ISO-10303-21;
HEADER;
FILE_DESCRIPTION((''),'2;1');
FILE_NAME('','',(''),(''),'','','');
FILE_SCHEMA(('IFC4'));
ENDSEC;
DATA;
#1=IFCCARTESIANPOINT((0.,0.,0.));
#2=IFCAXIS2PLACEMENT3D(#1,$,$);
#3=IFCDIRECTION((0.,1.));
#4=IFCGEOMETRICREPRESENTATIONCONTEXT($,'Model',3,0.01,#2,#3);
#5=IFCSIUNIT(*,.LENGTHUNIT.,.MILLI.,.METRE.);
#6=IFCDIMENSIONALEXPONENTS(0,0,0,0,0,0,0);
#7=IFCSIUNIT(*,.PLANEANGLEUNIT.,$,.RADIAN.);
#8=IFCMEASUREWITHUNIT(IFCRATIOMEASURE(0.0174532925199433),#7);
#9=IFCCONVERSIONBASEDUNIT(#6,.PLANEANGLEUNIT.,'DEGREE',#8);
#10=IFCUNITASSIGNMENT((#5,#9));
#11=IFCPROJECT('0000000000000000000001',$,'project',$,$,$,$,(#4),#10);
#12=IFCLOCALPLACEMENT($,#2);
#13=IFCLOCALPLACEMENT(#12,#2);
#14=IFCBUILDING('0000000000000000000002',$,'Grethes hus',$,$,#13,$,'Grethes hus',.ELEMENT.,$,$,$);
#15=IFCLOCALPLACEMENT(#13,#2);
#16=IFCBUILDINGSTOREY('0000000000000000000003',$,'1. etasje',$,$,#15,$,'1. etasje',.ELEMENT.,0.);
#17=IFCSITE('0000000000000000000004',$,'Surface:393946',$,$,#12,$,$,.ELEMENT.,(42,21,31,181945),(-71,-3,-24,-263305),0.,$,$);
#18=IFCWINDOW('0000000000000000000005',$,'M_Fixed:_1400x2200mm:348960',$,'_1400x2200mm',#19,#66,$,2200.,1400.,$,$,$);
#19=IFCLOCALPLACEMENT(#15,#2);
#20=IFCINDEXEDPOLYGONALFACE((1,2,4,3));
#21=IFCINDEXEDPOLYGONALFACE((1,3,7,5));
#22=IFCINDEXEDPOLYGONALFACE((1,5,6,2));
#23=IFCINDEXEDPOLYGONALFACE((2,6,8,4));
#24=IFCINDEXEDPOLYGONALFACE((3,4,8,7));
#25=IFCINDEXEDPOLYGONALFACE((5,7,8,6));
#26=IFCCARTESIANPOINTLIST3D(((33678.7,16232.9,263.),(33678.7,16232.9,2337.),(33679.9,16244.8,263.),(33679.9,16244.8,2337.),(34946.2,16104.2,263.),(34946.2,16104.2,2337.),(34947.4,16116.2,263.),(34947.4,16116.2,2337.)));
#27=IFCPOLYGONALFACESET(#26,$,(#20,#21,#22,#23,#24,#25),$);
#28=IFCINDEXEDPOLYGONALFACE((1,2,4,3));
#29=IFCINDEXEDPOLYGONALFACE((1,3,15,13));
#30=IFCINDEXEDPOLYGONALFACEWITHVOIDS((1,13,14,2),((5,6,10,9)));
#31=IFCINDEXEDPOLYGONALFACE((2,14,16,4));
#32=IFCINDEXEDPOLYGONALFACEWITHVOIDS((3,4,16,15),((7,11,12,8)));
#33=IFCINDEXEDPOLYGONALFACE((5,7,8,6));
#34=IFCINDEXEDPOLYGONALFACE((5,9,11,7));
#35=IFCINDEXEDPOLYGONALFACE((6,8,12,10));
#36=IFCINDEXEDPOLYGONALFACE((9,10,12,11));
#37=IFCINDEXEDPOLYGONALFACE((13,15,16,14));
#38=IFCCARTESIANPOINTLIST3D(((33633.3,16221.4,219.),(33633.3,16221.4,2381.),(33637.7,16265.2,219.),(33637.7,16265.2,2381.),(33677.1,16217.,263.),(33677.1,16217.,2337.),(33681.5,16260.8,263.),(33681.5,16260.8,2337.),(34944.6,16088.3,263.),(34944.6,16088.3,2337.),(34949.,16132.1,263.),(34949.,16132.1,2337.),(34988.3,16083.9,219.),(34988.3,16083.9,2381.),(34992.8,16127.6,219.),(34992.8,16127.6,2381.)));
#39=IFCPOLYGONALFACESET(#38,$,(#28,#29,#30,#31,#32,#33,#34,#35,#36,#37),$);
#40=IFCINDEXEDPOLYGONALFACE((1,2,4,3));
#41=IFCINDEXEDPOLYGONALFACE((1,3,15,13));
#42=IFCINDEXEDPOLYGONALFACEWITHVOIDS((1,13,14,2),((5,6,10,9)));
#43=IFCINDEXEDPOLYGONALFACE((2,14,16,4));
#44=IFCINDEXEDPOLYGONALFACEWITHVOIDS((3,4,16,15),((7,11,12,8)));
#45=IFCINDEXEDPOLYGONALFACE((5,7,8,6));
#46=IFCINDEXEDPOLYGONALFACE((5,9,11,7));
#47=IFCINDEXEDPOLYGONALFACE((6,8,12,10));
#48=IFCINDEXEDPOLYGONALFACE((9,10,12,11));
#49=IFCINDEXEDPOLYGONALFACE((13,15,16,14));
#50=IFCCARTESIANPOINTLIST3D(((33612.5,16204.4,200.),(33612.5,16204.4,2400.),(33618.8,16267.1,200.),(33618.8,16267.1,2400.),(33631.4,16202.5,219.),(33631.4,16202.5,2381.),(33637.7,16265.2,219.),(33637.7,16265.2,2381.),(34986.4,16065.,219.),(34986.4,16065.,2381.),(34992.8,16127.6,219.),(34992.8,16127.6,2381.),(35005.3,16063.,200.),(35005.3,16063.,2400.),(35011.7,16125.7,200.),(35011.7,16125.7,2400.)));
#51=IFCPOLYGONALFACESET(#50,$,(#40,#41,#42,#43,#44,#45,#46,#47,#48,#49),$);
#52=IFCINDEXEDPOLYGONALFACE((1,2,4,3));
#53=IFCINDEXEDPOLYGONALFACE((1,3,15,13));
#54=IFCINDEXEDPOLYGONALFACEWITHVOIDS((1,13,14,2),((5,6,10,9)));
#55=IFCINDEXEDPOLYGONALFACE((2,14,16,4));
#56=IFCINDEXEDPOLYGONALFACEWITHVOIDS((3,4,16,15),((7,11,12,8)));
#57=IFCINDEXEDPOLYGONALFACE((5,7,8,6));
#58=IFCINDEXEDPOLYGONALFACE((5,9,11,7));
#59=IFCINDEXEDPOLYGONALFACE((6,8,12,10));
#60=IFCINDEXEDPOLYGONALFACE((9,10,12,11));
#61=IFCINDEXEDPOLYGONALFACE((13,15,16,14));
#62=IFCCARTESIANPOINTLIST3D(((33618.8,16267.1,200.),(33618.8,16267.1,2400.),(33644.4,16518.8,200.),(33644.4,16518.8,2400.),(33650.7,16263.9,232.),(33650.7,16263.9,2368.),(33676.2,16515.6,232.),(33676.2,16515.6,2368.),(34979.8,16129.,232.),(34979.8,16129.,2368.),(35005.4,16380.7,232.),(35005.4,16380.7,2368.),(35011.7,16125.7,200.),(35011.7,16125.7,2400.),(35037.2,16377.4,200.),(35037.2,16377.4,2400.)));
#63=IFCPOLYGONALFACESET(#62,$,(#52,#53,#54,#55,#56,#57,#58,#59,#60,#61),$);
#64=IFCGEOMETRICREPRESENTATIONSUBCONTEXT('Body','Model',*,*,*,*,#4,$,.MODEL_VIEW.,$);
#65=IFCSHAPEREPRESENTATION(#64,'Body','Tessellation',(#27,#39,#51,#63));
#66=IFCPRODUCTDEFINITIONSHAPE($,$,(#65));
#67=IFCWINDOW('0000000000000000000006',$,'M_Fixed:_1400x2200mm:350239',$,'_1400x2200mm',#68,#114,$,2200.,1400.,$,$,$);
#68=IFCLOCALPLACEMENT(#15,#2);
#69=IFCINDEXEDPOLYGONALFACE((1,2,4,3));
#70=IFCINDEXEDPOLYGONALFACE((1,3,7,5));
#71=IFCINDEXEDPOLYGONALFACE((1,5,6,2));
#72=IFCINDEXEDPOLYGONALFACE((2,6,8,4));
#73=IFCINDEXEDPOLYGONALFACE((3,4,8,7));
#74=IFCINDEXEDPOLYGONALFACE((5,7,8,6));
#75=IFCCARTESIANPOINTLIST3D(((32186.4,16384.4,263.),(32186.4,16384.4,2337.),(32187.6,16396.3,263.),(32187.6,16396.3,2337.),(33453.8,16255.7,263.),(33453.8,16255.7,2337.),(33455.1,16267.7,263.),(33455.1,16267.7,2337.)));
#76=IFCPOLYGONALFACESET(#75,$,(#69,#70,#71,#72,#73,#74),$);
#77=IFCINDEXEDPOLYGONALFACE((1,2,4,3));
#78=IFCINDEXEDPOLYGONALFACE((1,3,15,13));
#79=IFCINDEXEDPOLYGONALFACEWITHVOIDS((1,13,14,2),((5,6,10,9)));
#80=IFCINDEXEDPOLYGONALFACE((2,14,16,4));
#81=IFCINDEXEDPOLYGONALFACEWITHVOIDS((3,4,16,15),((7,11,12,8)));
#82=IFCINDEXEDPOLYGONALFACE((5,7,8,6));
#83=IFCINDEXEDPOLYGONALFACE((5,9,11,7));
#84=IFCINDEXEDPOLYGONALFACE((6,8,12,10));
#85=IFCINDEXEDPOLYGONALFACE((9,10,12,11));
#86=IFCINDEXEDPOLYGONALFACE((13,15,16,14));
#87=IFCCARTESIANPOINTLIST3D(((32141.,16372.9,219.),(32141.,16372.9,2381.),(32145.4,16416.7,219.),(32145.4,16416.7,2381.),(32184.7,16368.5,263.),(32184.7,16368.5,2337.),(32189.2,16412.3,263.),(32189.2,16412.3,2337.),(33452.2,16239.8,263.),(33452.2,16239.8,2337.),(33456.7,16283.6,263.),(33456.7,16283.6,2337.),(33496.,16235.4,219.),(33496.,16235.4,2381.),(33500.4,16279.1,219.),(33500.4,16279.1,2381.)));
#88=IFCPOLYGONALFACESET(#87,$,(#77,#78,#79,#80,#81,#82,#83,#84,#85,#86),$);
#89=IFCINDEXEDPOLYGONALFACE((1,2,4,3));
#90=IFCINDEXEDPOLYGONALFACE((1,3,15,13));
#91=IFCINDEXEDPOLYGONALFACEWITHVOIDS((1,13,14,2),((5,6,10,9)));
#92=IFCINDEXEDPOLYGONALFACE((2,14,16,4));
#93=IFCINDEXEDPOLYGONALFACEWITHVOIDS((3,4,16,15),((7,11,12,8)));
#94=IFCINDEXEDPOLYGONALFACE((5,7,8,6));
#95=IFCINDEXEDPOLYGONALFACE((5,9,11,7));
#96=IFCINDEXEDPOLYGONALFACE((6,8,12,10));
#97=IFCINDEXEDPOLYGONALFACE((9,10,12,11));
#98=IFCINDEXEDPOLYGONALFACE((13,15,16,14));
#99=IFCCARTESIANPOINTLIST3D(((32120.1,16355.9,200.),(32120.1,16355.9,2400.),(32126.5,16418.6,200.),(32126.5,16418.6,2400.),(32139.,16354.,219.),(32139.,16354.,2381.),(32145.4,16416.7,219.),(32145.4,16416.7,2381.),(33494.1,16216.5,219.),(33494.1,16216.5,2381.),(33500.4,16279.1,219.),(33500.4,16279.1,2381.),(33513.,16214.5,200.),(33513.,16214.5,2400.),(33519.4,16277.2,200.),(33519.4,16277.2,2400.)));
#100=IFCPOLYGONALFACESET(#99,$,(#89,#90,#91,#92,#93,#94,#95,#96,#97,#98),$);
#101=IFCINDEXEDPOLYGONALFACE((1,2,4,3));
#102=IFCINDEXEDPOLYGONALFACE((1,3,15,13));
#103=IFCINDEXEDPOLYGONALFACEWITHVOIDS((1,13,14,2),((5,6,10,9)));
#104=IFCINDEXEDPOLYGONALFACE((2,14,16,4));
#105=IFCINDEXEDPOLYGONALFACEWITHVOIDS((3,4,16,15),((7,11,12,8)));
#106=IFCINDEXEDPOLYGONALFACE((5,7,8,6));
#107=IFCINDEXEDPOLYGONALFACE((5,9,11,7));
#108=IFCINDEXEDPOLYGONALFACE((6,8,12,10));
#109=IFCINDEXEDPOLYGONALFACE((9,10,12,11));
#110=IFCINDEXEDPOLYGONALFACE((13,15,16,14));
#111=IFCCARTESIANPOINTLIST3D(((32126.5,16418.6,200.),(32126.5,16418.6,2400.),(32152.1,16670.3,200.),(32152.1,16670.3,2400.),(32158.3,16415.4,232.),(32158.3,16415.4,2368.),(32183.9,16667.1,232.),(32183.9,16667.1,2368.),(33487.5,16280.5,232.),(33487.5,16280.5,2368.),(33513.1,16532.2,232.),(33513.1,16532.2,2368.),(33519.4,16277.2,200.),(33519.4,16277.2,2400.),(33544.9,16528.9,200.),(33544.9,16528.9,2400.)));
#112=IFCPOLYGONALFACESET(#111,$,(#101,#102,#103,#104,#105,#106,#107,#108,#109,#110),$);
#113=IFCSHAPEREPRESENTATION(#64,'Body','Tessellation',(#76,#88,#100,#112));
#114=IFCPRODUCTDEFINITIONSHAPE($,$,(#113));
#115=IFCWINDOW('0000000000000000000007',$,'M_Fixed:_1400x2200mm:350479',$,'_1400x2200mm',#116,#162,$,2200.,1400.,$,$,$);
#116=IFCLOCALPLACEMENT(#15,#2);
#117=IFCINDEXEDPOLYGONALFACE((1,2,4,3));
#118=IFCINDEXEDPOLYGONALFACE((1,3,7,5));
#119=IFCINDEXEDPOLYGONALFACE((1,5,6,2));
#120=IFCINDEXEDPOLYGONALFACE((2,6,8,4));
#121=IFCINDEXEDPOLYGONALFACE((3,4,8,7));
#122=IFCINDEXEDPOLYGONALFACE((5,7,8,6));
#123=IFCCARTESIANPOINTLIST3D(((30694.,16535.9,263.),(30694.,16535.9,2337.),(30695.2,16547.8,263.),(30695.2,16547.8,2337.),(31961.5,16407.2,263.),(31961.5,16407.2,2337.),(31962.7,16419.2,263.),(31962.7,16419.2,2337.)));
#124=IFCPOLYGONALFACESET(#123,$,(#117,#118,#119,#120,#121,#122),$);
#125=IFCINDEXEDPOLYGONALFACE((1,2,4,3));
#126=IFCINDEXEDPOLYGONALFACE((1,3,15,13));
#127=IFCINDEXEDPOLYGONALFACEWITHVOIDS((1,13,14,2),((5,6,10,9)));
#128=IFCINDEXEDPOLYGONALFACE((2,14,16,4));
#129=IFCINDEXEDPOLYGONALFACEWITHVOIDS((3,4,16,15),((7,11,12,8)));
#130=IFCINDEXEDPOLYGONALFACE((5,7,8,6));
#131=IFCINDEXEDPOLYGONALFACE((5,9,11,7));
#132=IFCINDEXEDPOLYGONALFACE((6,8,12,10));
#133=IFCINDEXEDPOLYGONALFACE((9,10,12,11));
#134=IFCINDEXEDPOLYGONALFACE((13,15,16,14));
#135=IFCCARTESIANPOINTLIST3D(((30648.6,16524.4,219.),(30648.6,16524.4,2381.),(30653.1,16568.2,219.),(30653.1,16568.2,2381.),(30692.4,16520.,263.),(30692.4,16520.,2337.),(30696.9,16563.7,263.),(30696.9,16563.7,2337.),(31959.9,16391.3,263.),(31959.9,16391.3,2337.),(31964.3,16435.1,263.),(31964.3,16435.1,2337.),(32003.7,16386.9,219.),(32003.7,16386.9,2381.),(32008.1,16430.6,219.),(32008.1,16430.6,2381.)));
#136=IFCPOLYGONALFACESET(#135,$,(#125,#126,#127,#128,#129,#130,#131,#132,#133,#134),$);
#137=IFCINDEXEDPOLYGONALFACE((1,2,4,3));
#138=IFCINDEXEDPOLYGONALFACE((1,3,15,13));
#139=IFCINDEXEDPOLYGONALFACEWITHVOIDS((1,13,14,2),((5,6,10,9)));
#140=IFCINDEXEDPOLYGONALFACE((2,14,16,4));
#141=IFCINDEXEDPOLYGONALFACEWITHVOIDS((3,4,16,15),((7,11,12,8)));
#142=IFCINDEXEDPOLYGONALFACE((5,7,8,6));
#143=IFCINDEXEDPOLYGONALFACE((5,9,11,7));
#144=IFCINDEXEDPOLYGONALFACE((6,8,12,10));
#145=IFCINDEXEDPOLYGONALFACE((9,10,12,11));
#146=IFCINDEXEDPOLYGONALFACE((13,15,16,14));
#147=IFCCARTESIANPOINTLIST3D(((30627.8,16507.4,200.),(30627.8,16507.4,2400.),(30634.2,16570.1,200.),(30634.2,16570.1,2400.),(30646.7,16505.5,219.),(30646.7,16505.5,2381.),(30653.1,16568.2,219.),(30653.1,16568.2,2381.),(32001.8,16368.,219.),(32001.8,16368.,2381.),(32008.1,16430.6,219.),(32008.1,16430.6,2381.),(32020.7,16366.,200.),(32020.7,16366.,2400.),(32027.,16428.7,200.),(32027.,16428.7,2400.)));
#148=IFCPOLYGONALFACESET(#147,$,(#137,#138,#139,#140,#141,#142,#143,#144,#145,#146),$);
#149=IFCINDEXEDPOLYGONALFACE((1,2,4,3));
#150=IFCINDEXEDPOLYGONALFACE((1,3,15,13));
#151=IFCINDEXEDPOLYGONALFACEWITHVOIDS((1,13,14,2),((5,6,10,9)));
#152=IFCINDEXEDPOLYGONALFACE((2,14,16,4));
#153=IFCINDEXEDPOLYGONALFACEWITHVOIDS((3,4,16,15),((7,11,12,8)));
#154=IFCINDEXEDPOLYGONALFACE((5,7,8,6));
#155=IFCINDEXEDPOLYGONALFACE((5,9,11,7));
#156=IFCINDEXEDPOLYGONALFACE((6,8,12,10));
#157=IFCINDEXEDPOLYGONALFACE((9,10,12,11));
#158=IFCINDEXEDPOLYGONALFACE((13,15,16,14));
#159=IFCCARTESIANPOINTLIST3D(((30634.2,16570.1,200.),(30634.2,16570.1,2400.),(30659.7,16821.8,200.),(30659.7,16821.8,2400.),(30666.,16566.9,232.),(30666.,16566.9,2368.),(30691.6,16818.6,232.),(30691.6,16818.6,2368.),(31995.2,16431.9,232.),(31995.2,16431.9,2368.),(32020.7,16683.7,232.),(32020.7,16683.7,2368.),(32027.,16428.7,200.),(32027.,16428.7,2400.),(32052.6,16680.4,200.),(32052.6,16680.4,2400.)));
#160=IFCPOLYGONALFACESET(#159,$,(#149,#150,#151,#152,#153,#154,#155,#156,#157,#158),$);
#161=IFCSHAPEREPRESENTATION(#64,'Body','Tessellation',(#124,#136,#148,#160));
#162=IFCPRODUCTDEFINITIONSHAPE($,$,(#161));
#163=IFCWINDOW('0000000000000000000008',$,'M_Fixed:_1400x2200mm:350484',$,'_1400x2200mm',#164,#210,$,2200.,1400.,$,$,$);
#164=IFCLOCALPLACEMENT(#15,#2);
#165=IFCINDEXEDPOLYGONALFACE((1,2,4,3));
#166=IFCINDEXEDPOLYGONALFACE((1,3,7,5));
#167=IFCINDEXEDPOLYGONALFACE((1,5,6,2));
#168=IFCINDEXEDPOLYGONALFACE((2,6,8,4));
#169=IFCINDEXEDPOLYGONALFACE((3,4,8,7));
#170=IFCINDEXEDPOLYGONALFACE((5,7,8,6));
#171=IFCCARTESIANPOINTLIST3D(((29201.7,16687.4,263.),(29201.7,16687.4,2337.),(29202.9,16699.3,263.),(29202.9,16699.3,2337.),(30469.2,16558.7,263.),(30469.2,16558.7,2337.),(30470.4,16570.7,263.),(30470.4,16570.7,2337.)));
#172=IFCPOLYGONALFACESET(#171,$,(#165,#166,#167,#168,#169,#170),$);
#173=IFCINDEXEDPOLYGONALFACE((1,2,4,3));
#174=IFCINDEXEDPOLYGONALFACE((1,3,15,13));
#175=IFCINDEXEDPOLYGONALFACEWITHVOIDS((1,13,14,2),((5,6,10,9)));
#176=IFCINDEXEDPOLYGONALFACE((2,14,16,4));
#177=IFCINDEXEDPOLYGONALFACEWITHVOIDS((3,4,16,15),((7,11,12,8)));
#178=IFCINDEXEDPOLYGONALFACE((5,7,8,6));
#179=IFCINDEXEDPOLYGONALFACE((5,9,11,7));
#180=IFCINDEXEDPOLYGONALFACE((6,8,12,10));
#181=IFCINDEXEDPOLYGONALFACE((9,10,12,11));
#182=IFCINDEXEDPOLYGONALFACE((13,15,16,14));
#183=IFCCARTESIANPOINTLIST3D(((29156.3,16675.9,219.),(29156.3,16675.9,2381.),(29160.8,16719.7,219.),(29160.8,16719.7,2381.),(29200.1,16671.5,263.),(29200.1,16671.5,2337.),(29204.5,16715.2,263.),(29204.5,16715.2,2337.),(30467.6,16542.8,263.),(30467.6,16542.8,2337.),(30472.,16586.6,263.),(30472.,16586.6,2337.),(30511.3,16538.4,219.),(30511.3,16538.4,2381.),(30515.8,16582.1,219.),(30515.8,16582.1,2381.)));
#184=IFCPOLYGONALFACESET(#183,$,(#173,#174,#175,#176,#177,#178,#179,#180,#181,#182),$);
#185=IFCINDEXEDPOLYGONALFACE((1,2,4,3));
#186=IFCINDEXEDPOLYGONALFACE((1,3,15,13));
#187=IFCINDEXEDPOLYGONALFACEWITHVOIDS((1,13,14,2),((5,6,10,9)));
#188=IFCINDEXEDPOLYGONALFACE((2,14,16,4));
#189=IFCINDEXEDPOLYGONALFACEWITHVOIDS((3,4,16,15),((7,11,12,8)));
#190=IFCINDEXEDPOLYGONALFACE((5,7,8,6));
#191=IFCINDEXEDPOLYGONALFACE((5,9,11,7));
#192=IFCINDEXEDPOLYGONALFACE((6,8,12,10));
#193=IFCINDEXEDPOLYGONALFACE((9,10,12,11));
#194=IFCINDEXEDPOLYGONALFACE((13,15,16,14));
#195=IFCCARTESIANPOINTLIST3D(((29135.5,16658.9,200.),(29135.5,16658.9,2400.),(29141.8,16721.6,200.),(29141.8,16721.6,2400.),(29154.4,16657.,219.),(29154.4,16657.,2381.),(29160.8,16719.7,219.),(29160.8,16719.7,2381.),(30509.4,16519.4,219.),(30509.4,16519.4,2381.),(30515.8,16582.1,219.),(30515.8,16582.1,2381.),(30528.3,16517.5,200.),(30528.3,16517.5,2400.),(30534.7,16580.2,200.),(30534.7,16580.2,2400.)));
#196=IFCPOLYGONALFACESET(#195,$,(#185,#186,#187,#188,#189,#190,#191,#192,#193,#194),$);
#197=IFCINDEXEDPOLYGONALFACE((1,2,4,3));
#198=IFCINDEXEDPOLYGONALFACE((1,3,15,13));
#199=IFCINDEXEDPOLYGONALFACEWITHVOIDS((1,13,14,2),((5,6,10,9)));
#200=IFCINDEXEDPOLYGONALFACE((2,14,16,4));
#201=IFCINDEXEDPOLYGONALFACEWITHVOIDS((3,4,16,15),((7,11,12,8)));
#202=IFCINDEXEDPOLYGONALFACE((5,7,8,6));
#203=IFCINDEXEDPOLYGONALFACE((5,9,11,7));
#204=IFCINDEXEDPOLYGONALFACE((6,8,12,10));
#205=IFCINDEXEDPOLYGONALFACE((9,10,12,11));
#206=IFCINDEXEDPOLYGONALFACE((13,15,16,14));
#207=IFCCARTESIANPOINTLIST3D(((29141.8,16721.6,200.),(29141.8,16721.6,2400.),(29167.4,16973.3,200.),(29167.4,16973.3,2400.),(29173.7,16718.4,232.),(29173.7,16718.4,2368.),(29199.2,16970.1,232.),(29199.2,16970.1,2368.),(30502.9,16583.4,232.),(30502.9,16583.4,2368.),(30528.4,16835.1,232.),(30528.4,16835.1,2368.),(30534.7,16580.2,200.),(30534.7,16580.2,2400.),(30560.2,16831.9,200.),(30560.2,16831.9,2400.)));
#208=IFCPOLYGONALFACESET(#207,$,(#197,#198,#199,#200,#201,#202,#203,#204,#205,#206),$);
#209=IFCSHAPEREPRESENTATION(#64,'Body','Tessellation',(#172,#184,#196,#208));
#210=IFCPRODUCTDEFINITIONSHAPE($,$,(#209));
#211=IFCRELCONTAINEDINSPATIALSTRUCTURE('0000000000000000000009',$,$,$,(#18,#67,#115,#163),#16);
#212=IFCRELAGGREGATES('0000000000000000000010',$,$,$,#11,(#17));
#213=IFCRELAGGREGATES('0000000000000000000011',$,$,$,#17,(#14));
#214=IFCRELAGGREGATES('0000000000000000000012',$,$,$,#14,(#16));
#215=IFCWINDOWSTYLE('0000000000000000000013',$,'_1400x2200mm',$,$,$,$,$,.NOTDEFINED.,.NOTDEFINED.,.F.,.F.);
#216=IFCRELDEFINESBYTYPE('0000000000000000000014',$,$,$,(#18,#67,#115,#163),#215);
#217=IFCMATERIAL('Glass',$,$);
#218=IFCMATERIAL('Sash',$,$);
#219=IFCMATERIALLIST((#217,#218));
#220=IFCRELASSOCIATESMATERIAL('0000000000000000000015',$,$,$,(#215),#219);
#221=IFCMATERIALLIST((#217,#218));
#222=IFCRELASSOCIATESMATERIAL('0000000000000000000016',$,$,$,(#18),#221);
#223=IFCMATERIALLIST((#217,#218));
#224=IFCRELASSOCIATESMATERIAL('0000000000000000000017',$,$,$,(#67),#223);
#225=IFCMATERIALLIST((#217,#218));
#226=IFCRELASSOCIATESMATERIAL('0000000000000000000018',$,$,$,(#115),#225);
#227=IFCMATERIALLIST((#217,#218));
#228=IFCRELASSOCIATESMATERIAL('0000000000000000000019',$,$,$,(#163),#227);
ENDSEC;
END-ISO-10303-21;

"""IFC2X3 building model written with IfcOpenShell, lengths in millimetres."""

from ifc_helpers import new_model, entity, si_unit, converted_unit, direction, frame, frame_2d, origin, place, context, subcontext, project, spatial, polyline, rectangle, outline, extrude, source, transform, mapped, material, material_list, type_object, type_shapes, element, save


model = new_model("IFC2X3")

# Units and contexts
model_context = context("Model", 3, precision=0.01, world=origin(), true_north=direction((0.0, 1.0)))
body_context = subcontext(model_context, "Body", "Model", "MODEL_VIEW")
ifc_project = project(units=[si_unit("LENGTHUNIT", "METRE", prefix="MILLI"), converted_unit("PLANEANGLEUNIT", "DEGREE", entity("IfcRatioMeasure", 0.0174532925199433), si_unit("PLANEANGLEUNIT", "RADIAN"), dimensions=[0, 0, 0, 0, 0, 0, 0])], contexts=[model_context])

# Site, building, storey
site_placement = place(None, origin())
site = spatial("IfcSite", under=ifc_project, at=site_placement, Name="Surface:393946", CompositionType="ELEMENT", RefLatitude=(42, 21, 31, 181945), RefLongitude=(-71, -3, -24, -263305), RefElevation=0.0)
building_placement = place(site_placement, origin())
building = spatial("IfcBuilding", under=site, at=building_placement, Name="Grethes hus", LongName="Grethes hus", CompositionType="ELEMENT")
storey_placement = place(building_placement, origin())
storey = spatial("IfcBuildingStorey", under=building, at=storey_placement, Name="1. etasje", LongName="1. etasje", CompositionType="ELEMENT", Elevation=0.0)

# Windows
ifc_material_1 = material(Name="Glass")
ifc_material_2 = material(Name="Sash")
ifc_material_list_1 = material_list([ifc_material_1, ifc_material_2])
ifc_material_list_2 = material_list([ifc_material_1, ifc_material_2])
window_style_1 = type_object("IfcWindowStyle", Name="_1400x2200mm", ConstructionType="NOTDEFINED", OperationType="NOTDEFINED", ParameterTakesPrecedence=False, Sizeable=False, material=ifc_material_list_2)
shared_shape_1 = source(origin(), body_context, "Body", "SweptSolid", [
    extrude(rectangle(XDim=12.0, YDim=1274.0, at=frame_2d((0.0, 0.0), x_axis=(1.0, 0.0))), frame((700.0, 275.0, 63.0), z_axis=(0.0, 0.0, 1.0), x_axis=(0.0, -1.0, 0.0)), (0.0, 0.0, 1.0), 2074.0),
    extrude(outline(polyline([(-681.0, -1081.0), (681.0, -1081.0), (681.0, 1081.0), (-681.0, 1081.0), (-681.0, -1081.0)]), holes=[polyline([(-637.0, -1037.0), (-637.0, 1037.0), (637.0, 1037.0), (637.0, -1037.0), (-637.0, -1037.0)])]), frame((700.0, 253.0, 1100.0), z_axis=(0.0, 1.0, 0.0), x_axis=(1.0, 0.0, 0.0)), (0.0, 0.0, 1.0), 44.0),
    extrude(outline(polyline([(-700.0, -1100.0), (700.0, -1100.0), (700.0, 1100.0), (-700.0, 1100.0), (-700.0, -1100.0)]), holes=[polyline([(-681.0, -1081.0), (-681.0, 1081.0), (681.0, 1081.0), (681.0, -1081.0), (-681.0, -1081.0)])]), frame((700.0, 253.0, 1100.0), z_axis=(0.0, 1.0, 0.0), x_axis=(1.0, 0.0, 0.0)), (0.0, 0.0, 1.0), 63.0),
    extrude(outline(polyline([(-700.0, -1100.0), (700.0, -1100.0), (700.0, 1100.0), (-700.0, 1100.0), (-700.0, -1100.0)]), holes=[polyline([(-668.0, -1068.0), (-668.0, 1068.0), (668.0, 1068.0), (668.0, -1068.0), (-668.0, -1068.0)])]), frame((700.0, 0.0, 1100.0), z_axis=(0.0, 1.0, 0.0), x_axis=(1.0, 0.0, 0.0)), (0.0, 0.0, 1.0), 253.0),
])
type_shapes(window_style_1, [shared_shape_1])
placement_1 = place(storey_placement, frame((35426.2, 16179.1, 0.0), z_axis=(0.0, 0.0, 1.0), x_axis=(-0.994887, 0.100996, 0.0)))
placement_2 = place(placement_1, frame((407.0, -158.0, 200.0)))
window_1_placement = place(placement_2, origin())
element("IfcWindow", 1, at=window_1_placement, inside=storey, type_object=window_style_1, material=ifc_material_list_1, Name="M_Fixed:_1400x2200mm:348960", ObjectType="_1400x2200mm", OverallHeight=2200.0, OverallWidth=1400.0, context=body_context, shape_type="MappedRepresentation", body=[
    mapped(shared_shape_1, transform((0.0, 0.0, 0.0), scale=1.0)),
])
ifc_material_list_3 = material_list([ifc_material_1, ifc_material_2])
placement_3 = place(placement_1, frame((1907.0, -158.0, 200.0)))
window_2_placement = place(placement_3, origin())
element("IfcWindow", 2, at=window_2_placement, inside=storey, type_object=window_style_1, material=ifc_material_list_3, Name="M_Fixed:_1400x2200mm:350239", ObjectType="_1400x2200mm", OverallHeight=2200.0, OverallWidth=1400.0, context=body_context, shape_type="MappedRepresentation", body=[
    mapped(shared_shape_1, transform((0.0, 0.0, 0.0), scale=1.0)),
])
ifc_material_list_4 = material_list([ifc_material_1, ifc_material_2])
placement_4 = place(placement_1, frame((3407.0, -158.0, 200.0)))
window_3_placement = place(placement_4, origin())
element("IfcWindow", 3, at=window_3_placement, inside=storey, type_object=window_style_1, material=ifc_material_list_4, Name="M_Fixed:_1400x2200mm:350479", ObjectType="_1400x2200mm", OverallHeight=2200.0, OverallWidth=1400.0, context=body_context, shape_type="MappedRepresentation", body=[
    mapped(shared_shape_1, transform((0.0, 0.0, 0.0), scale=1.0)),
])
ifc_material_list_5 = material_list([ifc_material_1, ifc_material_2])
placement_5 = place(placement_1, frame((4907.0, -158.0, 200.0)))
window_4_placement = place(placement_5, origin())
element("IfcWindow", 4, at=window_4_placement, inside=storey, type_object=window_style_1, material=ifc_material_list_5, Name="M_Fixed:_1400x2200mm:350484", ObjectType="_1400x2200mm", OverallHeight=2200.0, OverallWidth=1400.0, context=body_context, shape_type="MappedRepresentation", body=[
    mapped(shared_shape_1, transform((0.0, 0.0, 0.0), scale=1.0)),
])

save(model, "model.ifc")
